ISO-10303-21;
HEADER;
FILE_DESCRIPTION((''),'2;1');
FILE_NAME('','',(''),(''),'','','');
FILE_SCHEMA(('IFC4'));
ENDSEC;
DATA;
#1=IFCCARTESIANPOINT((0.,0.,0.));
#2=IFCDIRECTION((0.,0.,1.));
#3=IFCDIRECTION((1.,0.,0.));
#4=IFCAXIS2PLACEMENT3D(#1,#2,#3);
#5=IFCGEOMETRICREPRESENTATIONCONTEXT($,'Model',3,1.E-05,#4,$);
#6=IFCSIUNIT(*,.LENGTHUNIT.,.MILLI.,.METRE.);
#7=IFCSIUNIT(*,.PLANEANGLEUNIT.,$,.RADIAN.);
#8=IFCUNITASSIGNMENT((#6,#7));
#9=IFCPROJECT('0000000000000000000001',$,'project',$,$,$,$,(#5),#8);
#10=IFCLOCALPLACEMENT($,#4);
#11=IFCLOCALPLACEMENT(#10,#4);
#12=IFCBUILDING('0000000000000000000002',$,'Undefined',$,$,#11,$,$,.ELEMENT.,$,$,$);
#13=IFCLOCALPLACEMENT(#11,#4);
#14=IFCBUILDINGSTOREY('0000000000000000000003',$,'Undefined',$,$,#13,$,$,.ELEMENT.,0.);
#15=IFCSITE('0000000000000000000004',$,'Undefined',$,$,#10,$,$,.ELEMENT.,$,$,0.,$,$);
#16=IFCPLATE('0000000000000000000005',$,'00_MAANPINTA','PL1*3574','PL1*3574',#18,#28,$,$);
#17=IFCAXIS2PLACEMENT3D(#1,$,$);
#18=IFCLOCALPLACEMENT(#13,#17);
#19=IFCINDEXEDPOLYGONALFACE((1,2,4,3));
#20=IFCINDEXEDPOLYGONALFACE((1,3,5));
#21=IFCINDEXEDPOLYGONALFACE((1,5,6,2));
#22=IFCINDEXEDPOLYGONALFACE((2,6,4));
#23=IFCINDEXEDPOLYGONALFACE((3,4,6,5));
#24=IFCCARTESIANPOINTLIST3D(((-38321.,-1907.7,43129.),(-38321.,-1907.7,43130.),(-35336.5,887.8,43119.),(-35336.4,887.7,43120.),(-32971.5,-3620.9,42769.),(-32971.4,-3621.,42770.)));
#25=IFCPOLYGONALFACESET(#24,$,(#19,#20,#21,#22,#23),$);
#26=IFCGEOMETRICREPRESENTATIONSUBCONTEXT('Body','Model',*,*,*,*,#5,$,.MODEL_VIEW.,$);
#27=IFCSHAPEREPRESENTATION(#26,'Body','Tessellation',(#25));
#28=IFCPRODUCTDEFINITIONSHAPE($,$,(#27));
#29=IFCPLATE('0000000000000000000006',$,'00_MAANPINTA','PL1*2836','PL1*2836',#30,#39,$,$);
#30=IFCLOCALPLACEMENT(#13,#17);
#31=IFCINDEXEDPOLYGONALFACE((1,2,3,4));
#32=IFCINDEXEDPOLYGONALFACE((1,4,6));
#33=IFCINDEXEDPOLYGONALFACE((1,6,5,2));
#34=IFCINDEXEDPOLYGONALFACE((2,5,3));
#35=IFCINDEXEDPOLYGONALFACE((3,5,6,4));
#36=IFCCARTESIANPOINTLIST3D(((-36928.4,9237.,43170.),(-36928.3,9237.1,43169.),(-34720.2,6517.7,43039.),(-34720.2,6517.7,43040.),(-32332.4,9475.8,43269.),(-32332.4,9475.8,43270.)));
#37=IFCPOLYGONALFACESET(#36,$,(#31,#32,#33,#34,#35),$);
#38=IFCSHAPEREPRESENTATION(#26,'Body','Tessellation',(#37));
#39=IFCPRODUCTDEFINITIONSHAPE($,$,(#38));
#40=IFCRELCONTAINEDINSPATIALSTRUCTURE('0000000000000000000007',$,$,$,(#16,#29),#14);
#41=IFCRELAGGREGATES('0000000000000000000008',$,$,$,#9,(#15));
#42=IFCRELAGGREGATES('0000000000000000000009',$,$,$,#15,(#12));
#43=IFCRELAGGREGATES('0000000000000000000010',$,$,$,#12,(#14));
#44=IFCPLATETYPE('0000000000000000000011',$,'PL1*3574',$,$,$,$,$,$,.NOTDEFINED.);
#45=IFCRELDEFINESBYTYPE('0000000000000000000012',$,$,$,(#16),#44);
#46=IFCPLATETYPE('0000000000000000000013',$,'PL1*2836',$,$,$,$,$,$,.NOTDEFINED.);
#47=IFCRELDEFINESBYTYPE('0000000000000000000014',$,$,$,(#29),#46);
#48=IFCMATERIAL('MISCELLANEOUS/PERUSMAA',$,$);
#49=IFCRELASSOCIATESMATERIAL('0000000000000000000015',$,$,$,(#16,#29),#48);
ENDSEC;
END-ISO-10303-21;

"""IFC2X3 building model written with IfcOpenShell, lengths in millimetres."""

from ifc_helpers import new_model, si_unit, frame, origin_with_axes, place, context, subcontext, project, spatial, polyline, outline, extrude, material, type_object, element, save


model = new_model("IFC2X3")

# Units and contexts
model_context = context("Model", 3, precision=1e-05, world=origin_with_axes())
body_context = subcontext(model_context, "Body", "Model", "MODEL_VIEW")
ifc_project = project(units=[si_unit("LENGTHUNIT", "METRE", prefix="MILLI"), si_unit("PLANEANGLEUNIT", "RADIAN")], contexts=[model_context])

# Site, building, storey
site_placement = place(None, origin_with_axes())
site = spatial("IfcSite", under=ifc_project, at=site_placement, Name="Undefined", CompositionType="ELEMENT", RefElevation=0.0)
building_placement = place(site_placement, origin_with_axes())
building = spatial("IfcBuilding", under=site, at=building_placement, Name="Undefined", CompositionType="ELEMENT")
storey_placement = place(building_placement, origin_with_axes())
storey = spatial("IfcBuildingStorey", under=building, at=storey_placement, Name="Undefined", CompositionType="ELEMENT", Elevation=0.0)

# Plates
ifc_material = material(Name="MISCELLANEOUS/PERUSMAA")
plate_type_1 = type_object("IfcPlateType", Name="PL1*3574", PredefinedType="NOTDEFINED")
plate_1_placement = place(storey_placement, frame((-35336.5, 887.8, 43119.5), z_axis=(-0.050871, 0.050743, -0.997415), x_axis=(0.463425, -0.883478, -0.068582)))
element("IfcPlate", 1, at=plate_1_placement, inside=storey, type_object=plate_type_1, material=ifc_material, Name="00_MAANPINTA", Description="PL1*3574", ObjectType="PL1*3574", context=body_context, shape_type="SweptSolid", body=[
    extrude(outline(polyline([(0.0, 0.0), (5103.4, 0.0), (1086.0, 3942.4), (0.0, 0.0)])), frame((0.0, 0.0, -0.5), z_axis=(0.0, 0.0, 1.0), x_axis=(1.0, 0.0, 0.0)), (0.0, 0.0, 1.0), 1.0),
])
plate_type_2 = type_object("IfcPlateType", Name="PL1*2836", PredefinedType="NOTDEFINED")
plate_2_placement = place(storey_placement, frame((-34720.2, 6517.7, 43039.5), z_axis=(0.018456, 0.062689, -0.997862), x_axis=(-0.629923, 0.775772, 0.037086)))
element("IfcPlate", 2, at=plate_2_placement, inside=storey, type_object=plate_type_2, material=ifc_material, Name="00_MAANPINTA", Description="PL1*2836", ObjectType="PL1*2836", context=body_context, shape_type="SweptSolid", body=[
    extrude(outline(polyline([(0.0, 0.0), (3505.4, 0.0), (799.2, 3723.7), (0.0, 0.0)])), frame((0.0, 0.0, -0.5), z_axis=(0.0, 0.0, 1.0), x_axis=(1.0, 0.0, 0.0)), (0.0, 0.0, 1.0), 1.0),
])

save(model, "model.ifc")
